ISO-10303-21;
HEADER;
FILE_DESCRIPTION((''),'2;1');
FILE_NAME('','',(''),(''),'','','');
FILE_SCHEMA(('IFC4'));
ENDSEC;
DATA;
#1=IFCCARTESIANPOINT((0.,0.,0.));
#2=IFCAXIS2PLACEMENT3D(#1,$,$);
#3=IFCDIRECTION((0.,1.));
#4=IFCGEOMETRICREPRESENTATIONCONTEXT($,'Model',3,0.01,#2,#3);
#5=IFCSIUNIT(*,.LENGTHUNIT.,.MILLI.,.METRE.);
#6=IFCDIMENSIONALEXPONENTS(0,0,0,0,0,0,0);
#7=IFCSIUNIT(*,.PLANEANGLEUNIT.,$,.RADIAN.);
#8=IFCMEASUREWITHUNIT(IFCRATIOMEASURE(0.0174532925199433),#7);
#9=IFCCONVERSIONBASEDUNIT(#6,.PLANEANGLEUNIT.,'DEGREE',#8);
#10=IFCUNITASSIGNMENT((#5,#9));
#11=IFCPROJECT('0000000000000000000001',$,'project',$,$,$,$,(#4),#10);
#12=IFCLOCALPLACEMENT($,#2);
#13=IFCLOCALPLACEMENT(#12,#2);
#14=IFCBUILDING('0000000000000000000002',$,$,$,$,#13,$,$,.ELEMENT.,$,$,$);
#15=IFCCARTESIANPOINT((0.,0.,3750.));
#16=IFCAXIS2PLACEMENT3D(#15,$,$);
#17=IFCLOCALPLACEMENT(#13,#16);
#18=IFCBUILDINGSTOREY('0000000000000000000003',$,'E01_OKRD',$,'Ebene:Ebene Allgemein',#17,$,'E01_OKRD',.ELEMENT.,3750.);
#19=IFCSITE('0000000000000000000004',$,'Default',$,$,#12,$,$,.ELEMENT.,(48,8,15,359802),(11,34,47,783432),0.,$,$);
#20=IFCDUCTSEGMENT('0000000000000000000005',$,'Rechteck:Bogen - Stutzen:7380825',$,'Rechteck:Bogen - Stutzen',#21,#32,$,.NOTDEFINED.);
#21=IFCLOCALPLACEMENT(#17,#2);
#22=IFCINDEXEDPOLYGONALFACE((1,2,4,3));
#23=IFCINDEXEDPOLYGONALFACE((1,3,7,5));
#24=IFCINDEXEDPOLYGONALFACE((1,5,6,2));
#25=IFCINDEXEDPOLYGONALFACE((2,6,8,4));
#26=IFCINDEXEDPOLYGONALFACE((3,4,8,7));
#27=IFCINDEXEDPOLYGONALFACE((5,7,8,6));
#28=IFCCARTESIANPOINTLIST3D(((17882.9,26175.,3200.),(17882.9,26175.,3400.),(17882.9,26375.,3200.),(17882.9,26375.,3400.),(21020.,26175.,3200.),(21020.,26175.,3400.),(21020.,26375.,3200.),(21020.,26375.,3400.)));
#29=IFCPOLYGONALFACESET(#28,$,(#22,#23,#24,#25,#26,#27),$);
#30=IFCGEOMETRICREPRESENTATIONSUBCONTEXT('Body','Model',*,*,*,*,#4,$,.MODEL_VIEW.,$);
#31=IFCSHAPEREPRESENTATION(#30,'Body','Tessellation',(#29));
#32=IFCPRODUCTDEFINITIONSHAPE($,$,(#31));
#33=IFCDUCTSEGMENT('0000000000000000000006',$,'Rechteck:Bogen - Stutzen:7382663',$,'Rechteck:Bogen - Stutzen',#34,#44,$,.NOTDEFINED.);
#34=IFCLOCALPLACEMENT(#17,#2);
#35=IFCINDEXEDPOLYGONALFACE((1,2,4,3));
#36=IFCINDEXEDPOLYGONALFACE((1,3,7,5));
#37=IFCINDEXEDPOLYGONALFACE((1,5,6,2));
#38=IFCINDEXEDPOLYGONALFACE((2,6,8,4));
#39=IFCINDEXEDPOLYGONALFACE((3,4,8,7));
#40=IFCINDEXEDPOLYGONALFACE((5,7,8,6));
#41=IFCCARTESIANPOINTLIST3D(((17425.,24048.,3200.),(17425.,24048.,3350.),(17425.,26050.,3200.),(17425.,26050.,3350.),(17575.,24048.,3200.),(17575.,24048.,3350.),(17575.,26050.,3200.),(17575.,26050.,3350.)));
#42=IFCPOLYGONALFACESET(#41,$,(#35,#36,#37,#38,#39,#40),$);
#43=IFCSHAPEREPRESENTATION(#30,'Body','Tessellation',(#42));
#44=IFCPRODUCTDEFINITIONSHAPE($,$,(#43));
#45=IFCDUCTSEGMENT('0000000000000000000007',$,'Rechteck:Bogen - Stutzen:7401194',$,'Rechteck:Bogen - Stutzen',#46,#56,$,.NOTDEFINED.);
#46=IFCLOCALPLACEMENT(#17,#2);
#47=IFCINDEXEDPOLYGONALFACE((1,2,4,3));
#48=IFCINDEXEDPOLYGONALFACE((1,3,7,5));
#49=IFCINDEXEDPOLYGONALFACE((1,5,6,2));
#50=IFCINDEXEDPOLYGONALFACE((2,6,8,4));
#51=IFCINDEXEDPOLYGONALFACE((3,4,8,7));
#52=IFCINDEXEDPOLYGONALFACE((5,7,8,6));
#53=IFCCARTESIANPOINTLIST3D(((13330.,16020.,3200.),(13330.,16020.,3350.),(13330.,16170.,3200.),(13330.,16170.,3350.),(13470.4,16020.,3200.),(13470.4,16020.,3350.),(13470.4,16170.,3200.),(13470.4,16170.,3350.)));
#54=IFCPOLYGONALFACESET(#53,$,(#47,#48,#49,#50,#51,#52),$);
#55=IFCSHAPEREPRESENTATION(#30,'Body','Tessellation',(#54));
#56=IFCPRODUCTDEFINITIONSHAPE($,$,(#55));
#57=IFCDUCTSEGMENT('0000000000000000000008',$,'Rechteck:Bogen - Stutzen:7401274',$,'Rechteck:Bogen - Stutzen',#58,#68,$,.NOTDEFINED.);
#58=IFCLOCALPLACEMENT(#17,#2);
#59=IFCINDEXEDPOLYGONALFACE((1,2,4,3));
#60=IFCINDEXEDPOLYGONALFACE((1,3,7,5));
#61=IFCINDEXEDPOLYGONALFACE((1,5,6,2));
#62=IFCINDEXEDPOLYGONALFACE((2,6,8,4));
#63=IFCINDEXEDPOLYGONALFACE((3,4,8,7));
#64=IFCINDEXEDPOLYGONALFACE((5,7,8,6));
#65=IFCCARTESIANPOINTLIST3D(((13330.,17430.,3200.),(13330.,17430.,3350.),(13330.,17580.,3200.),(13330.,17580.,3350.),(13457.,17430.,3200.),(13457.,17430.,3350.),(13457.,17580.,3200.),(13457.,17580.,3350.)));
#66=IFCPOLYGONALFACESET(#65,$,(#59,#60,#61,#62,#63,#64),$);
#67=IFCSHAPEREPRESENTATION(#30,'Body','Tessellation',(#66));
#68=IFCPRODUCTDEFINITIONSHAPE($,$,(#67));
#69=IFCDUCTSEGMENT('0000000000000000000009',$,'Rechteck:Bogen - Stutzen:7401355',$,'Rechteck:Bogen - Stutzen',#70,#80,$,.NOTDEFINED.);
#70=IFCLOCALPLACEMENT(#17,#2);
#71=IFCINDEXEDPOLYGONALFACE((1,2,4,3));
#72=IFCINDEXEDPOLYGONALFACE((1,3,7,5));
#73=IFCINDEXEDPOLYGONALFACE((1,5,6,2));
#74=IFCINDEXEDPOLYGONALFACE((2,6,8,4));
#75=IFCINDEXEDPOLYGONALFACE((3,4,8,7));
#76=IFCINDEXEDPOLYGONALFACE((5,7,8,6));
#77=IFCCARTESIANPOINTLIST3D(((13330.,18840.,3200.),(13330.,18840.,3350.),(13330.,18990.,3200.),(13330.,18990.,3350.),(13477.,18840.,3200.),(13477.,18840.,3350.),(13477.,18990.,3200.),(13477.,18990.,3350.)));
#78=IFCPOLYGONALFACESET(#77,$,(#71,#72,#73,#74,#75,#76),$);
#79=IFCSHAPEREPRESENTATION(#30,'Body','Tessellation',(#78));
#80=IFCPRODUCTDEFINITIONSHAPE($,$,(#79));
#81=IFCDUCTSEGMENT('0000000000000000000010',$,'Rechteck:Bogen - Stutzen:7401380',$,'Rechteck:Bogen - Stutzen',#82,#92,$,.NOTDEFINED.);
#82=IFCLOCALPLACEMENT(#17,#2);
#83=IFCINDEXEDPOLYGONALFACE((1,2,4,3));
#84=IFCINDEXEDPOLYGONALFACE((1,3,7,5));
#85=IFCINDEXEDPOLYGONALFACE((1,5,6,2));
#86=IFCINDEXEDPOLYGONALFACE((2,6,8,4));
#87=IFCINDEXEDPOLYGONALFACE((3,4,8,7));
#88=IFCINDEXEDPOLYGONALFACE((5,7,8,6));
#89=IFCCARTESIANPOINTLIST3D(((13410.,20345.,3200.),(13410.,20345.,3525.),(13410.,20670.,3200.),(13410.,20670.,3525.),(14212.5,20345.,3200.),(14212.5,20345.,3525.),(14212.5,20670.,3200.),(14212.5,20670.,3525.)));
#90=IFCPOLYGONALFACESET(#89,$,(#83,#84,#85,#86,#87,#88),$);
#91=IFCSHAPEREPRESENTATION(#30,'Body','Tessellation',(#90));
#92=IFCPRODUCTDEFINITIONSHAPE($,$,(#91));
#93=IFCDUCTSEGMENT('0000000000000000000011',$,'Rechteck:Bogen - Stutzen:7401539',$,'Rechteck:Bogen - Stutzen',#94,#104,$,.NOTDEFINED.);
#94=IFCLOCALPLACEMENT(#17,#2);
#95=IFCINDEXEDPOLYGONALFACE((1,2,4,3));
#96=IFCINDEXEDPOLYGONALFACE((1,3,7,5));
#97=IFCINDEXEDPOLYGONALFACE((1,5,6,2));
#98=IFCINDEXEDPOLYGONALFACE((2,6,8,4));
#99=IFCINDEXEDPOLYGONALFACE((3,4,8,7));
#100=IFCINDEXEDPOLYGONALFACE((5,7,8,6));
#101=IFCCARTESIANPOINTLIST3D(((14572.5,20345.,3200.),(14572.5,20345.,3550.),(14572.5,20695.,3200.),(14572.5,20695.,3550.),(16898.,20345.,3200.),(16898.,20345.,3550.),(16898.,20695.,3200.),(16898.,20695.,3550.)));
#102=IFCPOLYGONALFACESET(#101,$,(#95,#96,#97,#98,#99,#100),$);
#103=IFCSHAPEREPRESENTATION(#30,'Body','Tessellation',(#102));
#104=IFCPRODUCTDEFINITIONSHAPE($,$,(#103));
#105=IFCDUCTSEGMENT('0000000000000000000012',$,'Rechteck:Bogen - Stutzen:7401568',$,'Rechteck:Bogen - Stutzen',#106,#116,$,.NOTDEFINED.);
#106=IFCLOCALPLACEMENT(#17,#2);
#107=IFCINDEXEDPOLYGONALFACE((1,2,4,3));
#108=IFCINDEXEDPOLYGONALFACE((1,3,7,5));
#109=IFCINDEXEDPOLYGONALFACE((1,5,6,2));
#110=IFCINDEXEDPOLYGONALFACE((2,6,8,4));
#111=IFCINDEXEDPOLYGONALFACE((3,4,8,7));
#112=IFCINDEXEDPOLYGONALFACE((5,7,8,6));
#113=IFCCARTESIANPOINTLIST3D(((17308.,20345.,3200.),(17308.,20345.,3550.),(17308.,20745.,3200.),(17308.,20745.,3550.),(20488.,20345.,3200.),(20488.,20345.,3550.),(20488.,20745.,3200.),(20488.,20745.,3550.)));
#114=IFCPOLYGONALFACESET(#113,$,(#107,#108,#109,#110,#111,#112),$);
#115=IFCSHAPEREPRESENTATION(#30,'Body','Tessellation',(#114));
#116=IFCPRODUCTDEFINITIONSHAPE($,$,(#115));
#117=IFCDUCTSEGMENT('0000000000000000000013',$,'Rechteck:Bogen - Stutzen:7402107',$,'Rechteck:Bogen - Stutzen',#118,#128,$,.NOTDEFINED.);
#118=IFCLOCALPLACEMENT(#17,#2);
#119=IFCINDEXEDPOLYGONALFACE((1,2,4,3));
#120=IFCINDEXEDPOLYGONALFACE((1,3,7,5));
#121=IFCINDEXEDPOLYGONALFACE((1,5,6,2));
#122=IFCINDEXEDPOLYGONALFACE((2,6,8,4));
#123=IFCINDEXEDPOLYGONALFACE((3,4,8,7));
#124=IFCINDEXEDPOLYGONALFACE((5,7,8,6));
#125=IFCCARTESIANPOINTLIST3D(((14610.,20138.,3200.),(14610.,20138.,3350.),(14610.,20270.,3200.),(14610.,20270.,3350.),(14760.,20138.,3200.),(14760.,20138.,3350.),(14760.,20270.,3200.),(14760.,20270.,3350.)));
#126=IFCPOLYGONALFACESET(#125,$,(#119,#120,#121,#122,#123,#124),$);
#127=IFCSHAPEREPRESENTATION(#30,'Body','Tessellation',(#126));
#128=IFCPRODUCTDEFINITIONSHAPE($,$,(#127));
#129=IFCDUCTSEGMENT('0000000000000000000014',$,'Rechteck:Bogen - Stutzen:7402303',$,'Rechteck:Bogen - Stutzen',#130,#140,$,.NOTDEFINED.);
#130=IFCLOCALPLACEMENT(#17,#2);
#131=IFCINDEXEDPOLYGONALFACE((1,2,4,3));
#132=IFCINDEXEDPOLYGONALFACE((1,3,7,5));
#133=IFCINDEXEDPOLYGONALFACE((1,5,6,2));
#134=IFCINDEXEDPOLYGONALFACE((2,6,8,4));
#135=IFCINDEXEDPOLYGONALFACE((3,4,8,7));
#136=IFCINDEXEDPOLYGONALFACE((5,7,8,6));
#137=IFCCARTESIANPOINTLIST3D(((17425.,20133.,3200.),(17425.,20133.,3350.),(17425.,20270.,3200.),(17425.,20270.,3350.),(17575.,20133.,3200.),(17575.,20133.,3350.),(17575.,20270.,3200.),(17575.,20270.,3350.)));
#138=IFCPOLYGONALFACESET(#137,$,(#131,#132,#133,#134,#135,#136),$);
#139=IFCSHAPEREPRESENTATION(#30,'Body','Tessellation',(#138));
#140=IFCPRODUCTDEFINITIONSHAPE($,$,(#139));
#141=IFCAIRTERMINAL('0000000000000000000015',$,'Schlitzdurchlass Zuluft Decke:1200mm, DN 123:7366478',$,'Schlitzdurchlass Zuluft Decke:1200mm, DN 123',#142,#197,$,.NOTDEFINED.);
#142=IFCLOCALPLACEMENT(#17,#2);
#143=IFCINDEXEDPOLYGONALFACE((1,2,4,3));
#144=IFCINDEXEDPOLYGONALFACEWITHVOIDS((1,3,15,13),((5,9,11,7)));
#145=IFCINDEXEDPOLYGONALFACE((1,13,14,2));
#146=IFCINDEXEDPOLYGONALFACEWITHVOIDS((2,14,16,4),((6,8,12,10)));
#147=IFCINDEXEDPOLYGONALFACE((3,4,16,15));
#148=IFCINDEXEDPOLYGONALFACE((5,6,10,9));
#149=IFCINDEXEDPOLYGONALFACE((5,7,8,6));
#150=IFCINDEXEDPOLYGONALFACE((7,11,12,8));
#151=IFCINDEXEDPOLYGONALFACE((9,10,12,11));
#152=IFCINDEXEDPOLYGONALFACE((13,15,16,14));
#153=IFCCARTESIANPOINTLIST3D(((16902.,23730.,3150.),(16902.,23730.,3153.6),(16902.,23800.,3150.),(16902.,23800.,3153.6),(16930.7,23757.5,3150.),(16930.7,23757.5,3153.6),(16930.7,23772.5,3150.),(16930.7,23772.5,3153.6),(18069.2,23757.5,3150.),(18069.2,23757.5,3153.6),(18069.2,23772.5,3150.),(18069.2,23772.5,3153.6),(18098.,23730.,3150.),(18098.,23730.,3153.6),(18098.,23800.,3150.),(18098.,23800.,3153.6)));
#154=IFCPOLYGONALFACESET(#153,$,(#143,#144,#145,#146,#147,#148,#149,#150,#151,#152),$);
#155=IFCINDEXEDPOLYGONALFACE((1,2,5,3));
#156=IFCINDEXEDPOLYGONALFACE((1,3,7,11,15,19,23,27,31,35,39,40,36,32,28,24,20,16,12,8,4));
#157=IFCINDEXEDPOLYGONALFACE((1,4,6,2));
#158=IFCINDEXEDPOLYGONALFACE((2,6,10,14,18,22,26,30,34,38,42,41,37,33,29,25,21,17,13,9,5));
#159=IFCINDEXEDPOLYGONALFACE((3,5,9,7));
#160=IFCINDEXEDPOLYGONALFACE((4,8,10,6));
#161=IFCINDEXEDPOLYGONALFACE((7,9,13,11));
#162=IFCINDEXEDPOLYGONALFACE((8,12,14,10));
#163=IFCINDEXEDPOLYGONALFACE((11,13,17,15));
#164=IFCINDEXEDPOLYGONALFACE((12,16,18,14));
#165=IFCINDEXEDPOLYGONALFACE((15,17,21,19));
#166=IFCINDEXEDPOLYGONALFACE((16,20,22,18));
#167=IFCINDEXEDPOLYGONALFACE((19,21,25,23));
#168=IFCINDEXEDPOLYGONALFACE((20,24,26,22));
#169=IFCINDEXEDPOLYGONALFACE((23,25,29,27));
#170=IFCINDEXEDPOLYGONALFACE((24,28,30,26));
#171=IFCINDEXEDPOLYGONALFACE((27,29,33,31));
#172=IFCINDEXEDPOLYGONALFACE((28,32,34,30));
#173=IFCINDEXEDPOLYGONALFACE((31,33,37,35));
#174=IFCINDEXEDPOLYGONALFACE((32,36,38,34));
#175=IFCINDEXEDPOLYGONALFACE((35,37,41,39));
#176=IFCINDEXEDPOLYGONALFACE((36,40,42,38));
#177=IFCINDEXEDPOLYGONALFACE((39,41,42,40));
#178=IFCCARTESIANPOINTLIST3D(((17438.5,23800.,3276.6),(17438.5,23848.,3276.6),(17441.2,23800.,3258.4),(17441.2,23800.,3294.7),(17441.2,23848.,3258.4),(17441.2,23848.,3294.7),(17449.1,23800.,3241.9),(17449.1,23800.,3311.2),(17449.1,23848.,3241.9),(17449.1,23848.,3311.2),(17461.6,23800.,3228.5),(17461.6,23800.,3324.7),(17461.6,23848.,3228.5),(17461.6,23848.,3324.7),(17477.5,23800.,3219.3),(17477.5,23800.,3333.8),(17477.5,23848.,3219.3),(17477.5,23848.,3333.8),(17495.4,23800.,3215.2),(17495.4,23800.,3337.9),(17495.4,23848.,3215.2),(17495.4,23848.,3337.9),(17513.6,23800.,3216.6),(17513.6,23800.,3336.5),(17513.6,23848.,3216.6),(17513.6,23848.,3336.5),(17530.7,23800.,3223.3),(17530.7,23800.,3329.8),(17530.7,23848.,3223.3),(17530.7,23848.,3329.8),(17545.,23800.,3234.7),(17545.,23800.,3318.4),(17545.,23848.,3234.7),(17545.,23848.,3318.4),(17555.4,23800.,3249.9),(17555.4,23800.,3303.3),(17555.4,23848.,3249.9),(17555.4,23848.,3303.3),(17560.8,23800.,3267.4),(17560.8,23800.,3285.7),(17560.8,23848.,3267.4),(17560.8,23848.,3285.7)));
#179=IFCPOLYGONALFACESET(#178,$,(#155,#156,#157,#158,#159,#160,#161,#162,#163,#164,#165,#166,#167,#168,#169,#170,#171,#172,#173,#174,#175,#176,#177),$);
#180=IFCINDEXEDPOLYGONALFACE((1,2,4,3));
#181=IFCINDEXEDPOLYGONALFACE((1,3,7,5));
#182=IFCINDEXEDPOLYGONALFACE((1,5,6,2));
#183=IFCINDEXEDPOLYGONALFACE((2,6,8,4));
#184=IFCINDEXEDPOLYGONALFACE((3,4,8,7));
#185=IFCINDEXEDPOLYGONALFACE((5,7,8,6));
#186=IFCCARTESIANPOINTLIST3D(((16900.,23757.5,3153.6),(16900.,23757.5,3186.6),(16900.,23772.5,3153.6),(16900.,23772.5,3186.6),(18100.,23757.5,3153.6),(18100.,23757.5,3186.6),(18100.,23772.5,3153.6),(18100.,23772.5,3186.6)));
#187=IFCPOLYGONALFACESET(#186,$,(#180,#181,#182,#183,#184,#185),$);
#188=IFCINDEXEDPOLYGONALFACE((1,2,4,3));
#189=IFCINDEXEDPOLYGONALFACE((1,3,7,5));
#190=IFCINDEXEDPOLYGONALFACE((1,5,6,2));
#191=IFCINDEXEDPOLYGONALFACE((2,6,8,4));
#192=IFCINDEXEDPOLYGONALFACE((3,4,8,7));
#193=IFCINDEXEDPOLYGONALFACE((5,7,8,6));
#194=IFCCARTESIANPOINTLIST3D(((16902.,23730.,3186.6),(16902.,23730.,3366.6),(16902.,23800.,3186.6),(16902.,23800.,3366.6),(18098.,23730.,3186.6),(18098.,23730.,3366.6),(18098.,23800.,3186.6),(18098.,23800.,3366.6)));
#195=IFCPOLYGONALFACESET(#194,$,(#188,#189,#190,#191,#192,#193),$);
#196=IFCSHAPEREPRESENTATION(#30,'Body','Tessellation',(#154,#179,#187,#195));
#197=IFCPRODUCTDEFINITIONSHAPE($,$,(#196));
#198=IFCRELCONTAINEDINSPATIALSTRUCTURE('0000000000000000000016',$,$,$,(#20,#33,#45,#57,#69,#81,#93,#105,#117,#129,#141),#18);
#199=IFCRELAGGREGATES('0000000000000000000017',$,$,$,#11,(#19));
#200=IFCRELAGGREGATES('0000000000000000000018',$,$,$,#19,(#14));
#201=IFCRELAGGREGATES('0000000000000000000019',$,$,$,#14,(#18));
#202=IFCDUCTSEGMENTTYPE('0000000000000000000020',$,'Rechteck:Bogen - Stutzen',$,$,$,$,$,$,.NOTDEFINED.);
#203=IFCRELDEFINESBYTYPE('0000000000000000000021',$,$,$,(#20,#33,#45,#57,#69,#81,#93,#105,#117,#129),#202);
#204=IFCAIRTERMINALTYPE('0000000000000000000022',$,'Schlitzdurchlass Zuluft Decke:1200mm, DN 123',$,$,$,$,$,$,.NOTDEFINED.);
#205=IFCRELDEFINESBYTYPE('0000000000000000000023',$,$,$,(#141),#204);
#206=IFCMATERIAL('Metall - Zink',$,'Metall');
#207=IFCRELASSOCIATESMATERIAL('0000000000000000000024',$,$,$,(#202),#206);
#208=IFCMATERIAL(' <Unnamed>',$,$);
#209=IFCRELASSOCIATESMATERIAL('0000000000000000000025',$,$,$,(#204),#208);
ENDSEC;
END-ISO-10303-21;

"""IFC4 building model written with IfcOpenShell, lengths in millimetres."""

from ifc_helpers import new_model, entity, si_unit, converted_unit, direction, frame, frame_2d, origin, origin_2d_with_axis, place, context, subcontext, project, spatial, polyline, rectangle, circle, outline, extrude, source, transform, mapped, material, type_object, type_shapes, element, save


model = new_model("IFC4")

# Units and contexts
model_context = context("Model", 3, precision=0.01, world=origin(), true_north=direction((0.0, 1.0)))
body_context = subcontext(model_context, "Body", "Model", "MODEL_VIEW")
ifc_project = project(units=[si_unit("LENGTHUNIT", "METRE", prefix="MILLI"), converted_unit("PLANEANGLEUNIT", "DEGREE", entity("IfcRatioMeasure", 0.0174532925199433), si_unit("PLANEANGLEUNIT", "RADIAN"), dimensions=[0, 0, 0, 0, 0, 0, 0])], contexts=[model_context])

# Site, building, storey
site_placement = place(None, origin())
site = spatial("IfcSite", under=ifc_project, at=site_placement, Name="Default", CompositionType="ELEMENT", RefLatitude=(48, 8, 15, 359802), RefLongitude=(11, 34, 47, 783432), RefElevation=0.0)
building_placement = place(site_placement, origin())
building = spatial("IfcBuilding", under=site, at=building_placement, CompositionType="ELEMENT")
storey_placement = place(building_placement, frame((0.0, 0.0, 3750.0)))
storey = spatial("IfcBuildingStorey", under=building, at=storey_placement, Name="E01_OKRD", ObjectType="Ebene:Ebene Allgemein", LongName="E01_OKRD", CompositionType="ELEMENT", Elevation=3750.0)

# Duct segments
ifc_material_1 = material(Name="Metall - Zink", Category="Metall")
duct_segment_type_1 = type_object("IfcDuctSegmentType", Name="Rechteck:Bogen - Stutzen", PredefinedType="NOTDEFINED", material=ifc_material_1)
duct_segment_1_placement = place(storey_placement, frame((17882.9, 26175.0, 3200.0)))
element("IfcDuctSegment", 1, at=duct_segment_1_placement, inside=storey, type_object=duct_segment_type_1, Name="Rechteck:Bogen - Stutzen:7380825", ObjectType="Rechteck:Bogen - Stutzen", PredefinedType="NOTDEFINED", context=body_context, shape_type="SweptSolid", body=[
    extrude(rectangle(XDim=3137.0, YDim=200.0, at=origin_2d_with_axis()), frame((1568.5, 100.0, 0.0), z_axis=(0.0, 0.0, 1.0), x_axis=(-1.0, 0.0, 0.0)), (0.0, 0.0, 1.0), 200.0),
])
duct_segment_2_placement = place(storey_placement, frame((17425.0, 24048.0, 3200.0)))
element("IfcDuctSegment", 2, at=duct_segment_2_placement, inside=storey, type_object=duct_segment_type_1, Name="Rechteck:Bogen - Stutzen:7382663", ObjectType="Rechteck:Bogen - Stutzen", PredefinedType="NOTDEFINED", context=body_context, shape_type="SweptSolid", body=[
    extrude(rectangle(XDim=2002.0, YDim=150.0, at=origin_2d_with_axis()), frame((75.0, 1001.0, 0.0), z_axis=(0.0, 0.0, 1.0), x_axis=(0.0, 1.0, 0.0)), (0.0, 0.0, 1.0), 150.0),
])
duct_segment_3_placement = place(storey_placement, frame((13330.0, 16020.0, 3200.0)))
element("IfcDuctSegment", 3, at=duct_segment_3_placement, inside=storey, type_object=duct_segment_type_1, Name="Rechteck:Bogen - Stutzen:7401194", ObjectType="Rechteck:Bogen - Stutzen", PredefinedType="NOTDEFINED", context=body_context, shape_type="SweptSolid", body=[
    extrude(rectangle(XDim=140.4, YDim=150.0, at=frame_2d((0.0, 0.0), x_axis=(1.0, 0.0))), frame((70.2, 75.0, 0.0), z_axis=(0.0, 0.0, 1.0), x_axis=(-1.0, 0.0, 0.0)), (0.0, 0.0, 1.0), 150.0),
])
duct_segment_4_placement = place(storey_placement, frame((13330.0, 17430.0, 3200.0)))
element("IfcDuctSegment", 4, at=duct_segment_4_placement, inside=storey, type_object=duct_segment_type_1, Name="Rechteck:Bogen - Stutzen:7401274", ObjectType="Rechteck:Bogen - Stutzen", PredefinedType="NOTDEFINED", context=body_context, shape_type="SweptSolid", body=[
    extrude(rectangle(XDim=127.0, YDim=150.0, at=frame_2d((0.0, 0.0), x_axis=(1.0, 0.0))), frame((63.5, 75.0, 0.0), z_axis=(0.0, 0.0, 1.0), x_axis=(-1.0, 0.0, 0.0)), (0.0, 0.0, 1.0), 150.0),
])
duct_segment_5_placement = place(storey_placement, frame((13330.0, 18840.0, 3200.0)))
element("IfcDuctSegment", 5, at=duct_segment_5_placement, inside=storey, type_object=duct_segment_type_1, Name="Rechteck:Bogen - Stutzen:7401355", ObjectType="Rechteck:Bogen - Stutzen", PredefinedType="NOTDEFINED", context=body_context, shape_type="SweptSolid", body=[
    extrude(rectangle(XDim=147.0, YDim=150.0, at=origin_2d_with_axis()), frame((73.5, 75.0, 0.0), z_axis=(0.0, 0.0, 1.0), x_axis=(-1.0, 0.0, 0.0)), (0.0, 0.0, 1.0), 150.0),
])
duct_segment_6_placement = place(storey_placement, frame((13410.0, 20345.0, 3200.0)))
element("IfcDuctSegment", 6, at=duct_segment_6_placement, inside=storey, type_object=duct_segment_type_1, Name="Rechteck:Bogen - Stutzen:7401380", ObjectType="Rechteck:Bogen - Stutzen", PredefinedType="NOTDEFINED", context=body_context, shape_type="SweptSolid", body=[
    extrude(rectangle(XDim=802.5, YDim=325.0, at=frame_2d((0.0, 0.0), x_axis=(1.0, 0.0))), frame((401.3, 162.5, 0.0)), (0.0, 0.0, 1.0), 325.0),
])
duct_segment_7_placement = place(storey_placement, frame((14572.5, 20345.0, 3200.0)))
element("IfcDuctSegment", 7, at=duct_segment_7_placement, inside=storey, type_object=duct_segment_type_1, Name="Rechteck:Bogen - Stutzen:7401539", ObjectType="Rechteck:Bogen - Stutzen", PredefinedType="NOTDEFINED", context=body_context, shape_type="SweptSolid", body=[
    extrude(rectangle(XDim=2325.6, YDim=350.0, at=origin_2d_with_axis()), frame((1162.8, 175.0, 0.0)), (0.0, 0.0, 1.0), 350.0),
])
duct_segment_8_placement = place(storey_placement, frame((17308.0, 20345.0, 3200.0)))
element("IfcDuctSegment", 8, at=duct_segment_8_placement, inside=storey, type_object=duct_segment_type_1, Name="Rechteck:Bogen - Stutzen:7401568", ObjectType="Rechteck:Bogen - Stutzen", PredefinedType="NOTDEFINED", context=body_context, shape_type="SweptSolid", body=[
    extrude(rectangle(XDim=3180.0, YDim=400.0, at=frame_2d((0.0, 0.0), x_axis=(1.0, 0.0))), frame((1590.0, 200.0, 0.0)), (0.0, 0.0, 1.0), 350.0),
])
duct_segment_9_placement = place(storey_placement, frame((14610.0, 20138.0, 3200.0)))
element("IfcDuctSegment", 9, at=duct_segment_9_placement, inside=storey, type_object=duct_segment_type_1, Name="Rechteck:Bogen - Stutzen:7402107", ObjectType="Rechteck:Bogen - Stutzen", PredefinedType="NOTDEFINED", context=body_context, shape_type="SweptSolid", body=[
    extrude(rectangle(XDim=132.0, YDim=150.0, at=frame_2d((0.0, 0.0), x_axis=(1.0, 0.0))), frame((75.0, 66.0, 0.0), z_axis=(0.0, 0.0, 1.0), x_axis=(0.0, 1.0, 0.0)), (0.0, 0.0, 1.0), 150.0),
])
duct_segment_10_placement = place(storey_placement, frame((17425.0, 20133.0, 3200.0)))
element("IfcDuctSegment", 10, at=duct_segment_10_placement, inside=storey, type_object=duct_segment_type_1, Name="Rechteck:Bogen - Stutzen:7402303", ObjectType="Rechteck:Bogen - Stutzen", PredefinedType="NOTDEFINED", context=body_context, shape_type="SweptSolid", body=[
    extrude(rectangle(XDim=137.0, YDim=150.0, at=origin_2d_with_axis()), frame((75.0, 68.5, 0.0), z_axis=(0.0, 0.0, 1.0), x_axis=(0.0, 1.0, 0.0)), (0.0, 0.0, 1.0), 150.0),
])

# Air terminal
ifc_material_2 = material(Name=" <Unnamed>")
air_terminal_type_1 = type_object("IfcAirTerminalType", Name="Schlitzdurchlass Zuluft Decke:1200mm, DN 123", PredefinedType="NOTDEFINED", material=ifc_material_2)
shared_shape_1 = source(origin(), body_context, "Body", "SweptSolid", [
    extrude(outline(polyline([(-598.0, -35.0), (598.0, -35.0), (598.0, 35.0), (-598.0, 35.0), (-598.0, -35.0)]), holes=[polyline([(-569.2, -7.5), (-569.2, 7.5), (569.2, 7.5), (569.2, -7.5), (-569.2, -7.5)])]), frame((600.0, 35.0, 0.0), z_axis=(0.0, 0.0, 1.0), x_axis=(-1.0, 0.0, 0.0)), (0.0, 0.0, 1.0), 3.6),
    extrude(circle(Radius=61.5, at=frame_2d((0.0, 0.0), x_axis=(1.0, 0.0))), frame((600.0, 70.0, 126.6), z_axis=(0.0, 1.0, 0.0), x_axis=(-1.0, 0.0, 0.0)), (0.0, 0.0, 1.0), 48.0),
    extrude(rectangle(XDim=1200.0, YDim=15.0, at=origin_2d_with_axis()), frame((600.0, 35.0, 3.6), z_axis=(0.0, 0.0, 1.0), x_axis=(-1.0, 0.0, 0.0)), (0.0, 0.0, 1.0), 33.0),
    extrude(rectangle(XDim=1196.0, YDim=70.0, at=origin_2d_with_axis()), frame((600.0, 35.0, 36.6), z_axis=(0.0, 0.0, 1.0), x_axis=(-1.0, 0.0, 0.0)), (0.0, 0.0, 1.0), 180.0),
])
type_shapes(air_terminal_type_1, [shared_shape_1])
air_terminal_placement = place(storey_placement, frame((16900.0, 23730.0, 3150.0)))
element("IfcAirTerminal", 11, at=air_terminal_placement, inside=storey, type_object=air_terminal_type_1, Name="Schlitzdurchlass Zuluft Decke:1200mm, DN 123:7366478", ObjectType="Schlitzdurchlass Zuluft Decke:1200mm, DN 123", PredefinedType="NOTDEFINED", context=body_context, shape_type="MappedRepresentation", body=[
    mapped(shared_shape_1, transform((0.0, 0.0, 0.0), scale=1.0)),
])

save(model, "model.ifc")
